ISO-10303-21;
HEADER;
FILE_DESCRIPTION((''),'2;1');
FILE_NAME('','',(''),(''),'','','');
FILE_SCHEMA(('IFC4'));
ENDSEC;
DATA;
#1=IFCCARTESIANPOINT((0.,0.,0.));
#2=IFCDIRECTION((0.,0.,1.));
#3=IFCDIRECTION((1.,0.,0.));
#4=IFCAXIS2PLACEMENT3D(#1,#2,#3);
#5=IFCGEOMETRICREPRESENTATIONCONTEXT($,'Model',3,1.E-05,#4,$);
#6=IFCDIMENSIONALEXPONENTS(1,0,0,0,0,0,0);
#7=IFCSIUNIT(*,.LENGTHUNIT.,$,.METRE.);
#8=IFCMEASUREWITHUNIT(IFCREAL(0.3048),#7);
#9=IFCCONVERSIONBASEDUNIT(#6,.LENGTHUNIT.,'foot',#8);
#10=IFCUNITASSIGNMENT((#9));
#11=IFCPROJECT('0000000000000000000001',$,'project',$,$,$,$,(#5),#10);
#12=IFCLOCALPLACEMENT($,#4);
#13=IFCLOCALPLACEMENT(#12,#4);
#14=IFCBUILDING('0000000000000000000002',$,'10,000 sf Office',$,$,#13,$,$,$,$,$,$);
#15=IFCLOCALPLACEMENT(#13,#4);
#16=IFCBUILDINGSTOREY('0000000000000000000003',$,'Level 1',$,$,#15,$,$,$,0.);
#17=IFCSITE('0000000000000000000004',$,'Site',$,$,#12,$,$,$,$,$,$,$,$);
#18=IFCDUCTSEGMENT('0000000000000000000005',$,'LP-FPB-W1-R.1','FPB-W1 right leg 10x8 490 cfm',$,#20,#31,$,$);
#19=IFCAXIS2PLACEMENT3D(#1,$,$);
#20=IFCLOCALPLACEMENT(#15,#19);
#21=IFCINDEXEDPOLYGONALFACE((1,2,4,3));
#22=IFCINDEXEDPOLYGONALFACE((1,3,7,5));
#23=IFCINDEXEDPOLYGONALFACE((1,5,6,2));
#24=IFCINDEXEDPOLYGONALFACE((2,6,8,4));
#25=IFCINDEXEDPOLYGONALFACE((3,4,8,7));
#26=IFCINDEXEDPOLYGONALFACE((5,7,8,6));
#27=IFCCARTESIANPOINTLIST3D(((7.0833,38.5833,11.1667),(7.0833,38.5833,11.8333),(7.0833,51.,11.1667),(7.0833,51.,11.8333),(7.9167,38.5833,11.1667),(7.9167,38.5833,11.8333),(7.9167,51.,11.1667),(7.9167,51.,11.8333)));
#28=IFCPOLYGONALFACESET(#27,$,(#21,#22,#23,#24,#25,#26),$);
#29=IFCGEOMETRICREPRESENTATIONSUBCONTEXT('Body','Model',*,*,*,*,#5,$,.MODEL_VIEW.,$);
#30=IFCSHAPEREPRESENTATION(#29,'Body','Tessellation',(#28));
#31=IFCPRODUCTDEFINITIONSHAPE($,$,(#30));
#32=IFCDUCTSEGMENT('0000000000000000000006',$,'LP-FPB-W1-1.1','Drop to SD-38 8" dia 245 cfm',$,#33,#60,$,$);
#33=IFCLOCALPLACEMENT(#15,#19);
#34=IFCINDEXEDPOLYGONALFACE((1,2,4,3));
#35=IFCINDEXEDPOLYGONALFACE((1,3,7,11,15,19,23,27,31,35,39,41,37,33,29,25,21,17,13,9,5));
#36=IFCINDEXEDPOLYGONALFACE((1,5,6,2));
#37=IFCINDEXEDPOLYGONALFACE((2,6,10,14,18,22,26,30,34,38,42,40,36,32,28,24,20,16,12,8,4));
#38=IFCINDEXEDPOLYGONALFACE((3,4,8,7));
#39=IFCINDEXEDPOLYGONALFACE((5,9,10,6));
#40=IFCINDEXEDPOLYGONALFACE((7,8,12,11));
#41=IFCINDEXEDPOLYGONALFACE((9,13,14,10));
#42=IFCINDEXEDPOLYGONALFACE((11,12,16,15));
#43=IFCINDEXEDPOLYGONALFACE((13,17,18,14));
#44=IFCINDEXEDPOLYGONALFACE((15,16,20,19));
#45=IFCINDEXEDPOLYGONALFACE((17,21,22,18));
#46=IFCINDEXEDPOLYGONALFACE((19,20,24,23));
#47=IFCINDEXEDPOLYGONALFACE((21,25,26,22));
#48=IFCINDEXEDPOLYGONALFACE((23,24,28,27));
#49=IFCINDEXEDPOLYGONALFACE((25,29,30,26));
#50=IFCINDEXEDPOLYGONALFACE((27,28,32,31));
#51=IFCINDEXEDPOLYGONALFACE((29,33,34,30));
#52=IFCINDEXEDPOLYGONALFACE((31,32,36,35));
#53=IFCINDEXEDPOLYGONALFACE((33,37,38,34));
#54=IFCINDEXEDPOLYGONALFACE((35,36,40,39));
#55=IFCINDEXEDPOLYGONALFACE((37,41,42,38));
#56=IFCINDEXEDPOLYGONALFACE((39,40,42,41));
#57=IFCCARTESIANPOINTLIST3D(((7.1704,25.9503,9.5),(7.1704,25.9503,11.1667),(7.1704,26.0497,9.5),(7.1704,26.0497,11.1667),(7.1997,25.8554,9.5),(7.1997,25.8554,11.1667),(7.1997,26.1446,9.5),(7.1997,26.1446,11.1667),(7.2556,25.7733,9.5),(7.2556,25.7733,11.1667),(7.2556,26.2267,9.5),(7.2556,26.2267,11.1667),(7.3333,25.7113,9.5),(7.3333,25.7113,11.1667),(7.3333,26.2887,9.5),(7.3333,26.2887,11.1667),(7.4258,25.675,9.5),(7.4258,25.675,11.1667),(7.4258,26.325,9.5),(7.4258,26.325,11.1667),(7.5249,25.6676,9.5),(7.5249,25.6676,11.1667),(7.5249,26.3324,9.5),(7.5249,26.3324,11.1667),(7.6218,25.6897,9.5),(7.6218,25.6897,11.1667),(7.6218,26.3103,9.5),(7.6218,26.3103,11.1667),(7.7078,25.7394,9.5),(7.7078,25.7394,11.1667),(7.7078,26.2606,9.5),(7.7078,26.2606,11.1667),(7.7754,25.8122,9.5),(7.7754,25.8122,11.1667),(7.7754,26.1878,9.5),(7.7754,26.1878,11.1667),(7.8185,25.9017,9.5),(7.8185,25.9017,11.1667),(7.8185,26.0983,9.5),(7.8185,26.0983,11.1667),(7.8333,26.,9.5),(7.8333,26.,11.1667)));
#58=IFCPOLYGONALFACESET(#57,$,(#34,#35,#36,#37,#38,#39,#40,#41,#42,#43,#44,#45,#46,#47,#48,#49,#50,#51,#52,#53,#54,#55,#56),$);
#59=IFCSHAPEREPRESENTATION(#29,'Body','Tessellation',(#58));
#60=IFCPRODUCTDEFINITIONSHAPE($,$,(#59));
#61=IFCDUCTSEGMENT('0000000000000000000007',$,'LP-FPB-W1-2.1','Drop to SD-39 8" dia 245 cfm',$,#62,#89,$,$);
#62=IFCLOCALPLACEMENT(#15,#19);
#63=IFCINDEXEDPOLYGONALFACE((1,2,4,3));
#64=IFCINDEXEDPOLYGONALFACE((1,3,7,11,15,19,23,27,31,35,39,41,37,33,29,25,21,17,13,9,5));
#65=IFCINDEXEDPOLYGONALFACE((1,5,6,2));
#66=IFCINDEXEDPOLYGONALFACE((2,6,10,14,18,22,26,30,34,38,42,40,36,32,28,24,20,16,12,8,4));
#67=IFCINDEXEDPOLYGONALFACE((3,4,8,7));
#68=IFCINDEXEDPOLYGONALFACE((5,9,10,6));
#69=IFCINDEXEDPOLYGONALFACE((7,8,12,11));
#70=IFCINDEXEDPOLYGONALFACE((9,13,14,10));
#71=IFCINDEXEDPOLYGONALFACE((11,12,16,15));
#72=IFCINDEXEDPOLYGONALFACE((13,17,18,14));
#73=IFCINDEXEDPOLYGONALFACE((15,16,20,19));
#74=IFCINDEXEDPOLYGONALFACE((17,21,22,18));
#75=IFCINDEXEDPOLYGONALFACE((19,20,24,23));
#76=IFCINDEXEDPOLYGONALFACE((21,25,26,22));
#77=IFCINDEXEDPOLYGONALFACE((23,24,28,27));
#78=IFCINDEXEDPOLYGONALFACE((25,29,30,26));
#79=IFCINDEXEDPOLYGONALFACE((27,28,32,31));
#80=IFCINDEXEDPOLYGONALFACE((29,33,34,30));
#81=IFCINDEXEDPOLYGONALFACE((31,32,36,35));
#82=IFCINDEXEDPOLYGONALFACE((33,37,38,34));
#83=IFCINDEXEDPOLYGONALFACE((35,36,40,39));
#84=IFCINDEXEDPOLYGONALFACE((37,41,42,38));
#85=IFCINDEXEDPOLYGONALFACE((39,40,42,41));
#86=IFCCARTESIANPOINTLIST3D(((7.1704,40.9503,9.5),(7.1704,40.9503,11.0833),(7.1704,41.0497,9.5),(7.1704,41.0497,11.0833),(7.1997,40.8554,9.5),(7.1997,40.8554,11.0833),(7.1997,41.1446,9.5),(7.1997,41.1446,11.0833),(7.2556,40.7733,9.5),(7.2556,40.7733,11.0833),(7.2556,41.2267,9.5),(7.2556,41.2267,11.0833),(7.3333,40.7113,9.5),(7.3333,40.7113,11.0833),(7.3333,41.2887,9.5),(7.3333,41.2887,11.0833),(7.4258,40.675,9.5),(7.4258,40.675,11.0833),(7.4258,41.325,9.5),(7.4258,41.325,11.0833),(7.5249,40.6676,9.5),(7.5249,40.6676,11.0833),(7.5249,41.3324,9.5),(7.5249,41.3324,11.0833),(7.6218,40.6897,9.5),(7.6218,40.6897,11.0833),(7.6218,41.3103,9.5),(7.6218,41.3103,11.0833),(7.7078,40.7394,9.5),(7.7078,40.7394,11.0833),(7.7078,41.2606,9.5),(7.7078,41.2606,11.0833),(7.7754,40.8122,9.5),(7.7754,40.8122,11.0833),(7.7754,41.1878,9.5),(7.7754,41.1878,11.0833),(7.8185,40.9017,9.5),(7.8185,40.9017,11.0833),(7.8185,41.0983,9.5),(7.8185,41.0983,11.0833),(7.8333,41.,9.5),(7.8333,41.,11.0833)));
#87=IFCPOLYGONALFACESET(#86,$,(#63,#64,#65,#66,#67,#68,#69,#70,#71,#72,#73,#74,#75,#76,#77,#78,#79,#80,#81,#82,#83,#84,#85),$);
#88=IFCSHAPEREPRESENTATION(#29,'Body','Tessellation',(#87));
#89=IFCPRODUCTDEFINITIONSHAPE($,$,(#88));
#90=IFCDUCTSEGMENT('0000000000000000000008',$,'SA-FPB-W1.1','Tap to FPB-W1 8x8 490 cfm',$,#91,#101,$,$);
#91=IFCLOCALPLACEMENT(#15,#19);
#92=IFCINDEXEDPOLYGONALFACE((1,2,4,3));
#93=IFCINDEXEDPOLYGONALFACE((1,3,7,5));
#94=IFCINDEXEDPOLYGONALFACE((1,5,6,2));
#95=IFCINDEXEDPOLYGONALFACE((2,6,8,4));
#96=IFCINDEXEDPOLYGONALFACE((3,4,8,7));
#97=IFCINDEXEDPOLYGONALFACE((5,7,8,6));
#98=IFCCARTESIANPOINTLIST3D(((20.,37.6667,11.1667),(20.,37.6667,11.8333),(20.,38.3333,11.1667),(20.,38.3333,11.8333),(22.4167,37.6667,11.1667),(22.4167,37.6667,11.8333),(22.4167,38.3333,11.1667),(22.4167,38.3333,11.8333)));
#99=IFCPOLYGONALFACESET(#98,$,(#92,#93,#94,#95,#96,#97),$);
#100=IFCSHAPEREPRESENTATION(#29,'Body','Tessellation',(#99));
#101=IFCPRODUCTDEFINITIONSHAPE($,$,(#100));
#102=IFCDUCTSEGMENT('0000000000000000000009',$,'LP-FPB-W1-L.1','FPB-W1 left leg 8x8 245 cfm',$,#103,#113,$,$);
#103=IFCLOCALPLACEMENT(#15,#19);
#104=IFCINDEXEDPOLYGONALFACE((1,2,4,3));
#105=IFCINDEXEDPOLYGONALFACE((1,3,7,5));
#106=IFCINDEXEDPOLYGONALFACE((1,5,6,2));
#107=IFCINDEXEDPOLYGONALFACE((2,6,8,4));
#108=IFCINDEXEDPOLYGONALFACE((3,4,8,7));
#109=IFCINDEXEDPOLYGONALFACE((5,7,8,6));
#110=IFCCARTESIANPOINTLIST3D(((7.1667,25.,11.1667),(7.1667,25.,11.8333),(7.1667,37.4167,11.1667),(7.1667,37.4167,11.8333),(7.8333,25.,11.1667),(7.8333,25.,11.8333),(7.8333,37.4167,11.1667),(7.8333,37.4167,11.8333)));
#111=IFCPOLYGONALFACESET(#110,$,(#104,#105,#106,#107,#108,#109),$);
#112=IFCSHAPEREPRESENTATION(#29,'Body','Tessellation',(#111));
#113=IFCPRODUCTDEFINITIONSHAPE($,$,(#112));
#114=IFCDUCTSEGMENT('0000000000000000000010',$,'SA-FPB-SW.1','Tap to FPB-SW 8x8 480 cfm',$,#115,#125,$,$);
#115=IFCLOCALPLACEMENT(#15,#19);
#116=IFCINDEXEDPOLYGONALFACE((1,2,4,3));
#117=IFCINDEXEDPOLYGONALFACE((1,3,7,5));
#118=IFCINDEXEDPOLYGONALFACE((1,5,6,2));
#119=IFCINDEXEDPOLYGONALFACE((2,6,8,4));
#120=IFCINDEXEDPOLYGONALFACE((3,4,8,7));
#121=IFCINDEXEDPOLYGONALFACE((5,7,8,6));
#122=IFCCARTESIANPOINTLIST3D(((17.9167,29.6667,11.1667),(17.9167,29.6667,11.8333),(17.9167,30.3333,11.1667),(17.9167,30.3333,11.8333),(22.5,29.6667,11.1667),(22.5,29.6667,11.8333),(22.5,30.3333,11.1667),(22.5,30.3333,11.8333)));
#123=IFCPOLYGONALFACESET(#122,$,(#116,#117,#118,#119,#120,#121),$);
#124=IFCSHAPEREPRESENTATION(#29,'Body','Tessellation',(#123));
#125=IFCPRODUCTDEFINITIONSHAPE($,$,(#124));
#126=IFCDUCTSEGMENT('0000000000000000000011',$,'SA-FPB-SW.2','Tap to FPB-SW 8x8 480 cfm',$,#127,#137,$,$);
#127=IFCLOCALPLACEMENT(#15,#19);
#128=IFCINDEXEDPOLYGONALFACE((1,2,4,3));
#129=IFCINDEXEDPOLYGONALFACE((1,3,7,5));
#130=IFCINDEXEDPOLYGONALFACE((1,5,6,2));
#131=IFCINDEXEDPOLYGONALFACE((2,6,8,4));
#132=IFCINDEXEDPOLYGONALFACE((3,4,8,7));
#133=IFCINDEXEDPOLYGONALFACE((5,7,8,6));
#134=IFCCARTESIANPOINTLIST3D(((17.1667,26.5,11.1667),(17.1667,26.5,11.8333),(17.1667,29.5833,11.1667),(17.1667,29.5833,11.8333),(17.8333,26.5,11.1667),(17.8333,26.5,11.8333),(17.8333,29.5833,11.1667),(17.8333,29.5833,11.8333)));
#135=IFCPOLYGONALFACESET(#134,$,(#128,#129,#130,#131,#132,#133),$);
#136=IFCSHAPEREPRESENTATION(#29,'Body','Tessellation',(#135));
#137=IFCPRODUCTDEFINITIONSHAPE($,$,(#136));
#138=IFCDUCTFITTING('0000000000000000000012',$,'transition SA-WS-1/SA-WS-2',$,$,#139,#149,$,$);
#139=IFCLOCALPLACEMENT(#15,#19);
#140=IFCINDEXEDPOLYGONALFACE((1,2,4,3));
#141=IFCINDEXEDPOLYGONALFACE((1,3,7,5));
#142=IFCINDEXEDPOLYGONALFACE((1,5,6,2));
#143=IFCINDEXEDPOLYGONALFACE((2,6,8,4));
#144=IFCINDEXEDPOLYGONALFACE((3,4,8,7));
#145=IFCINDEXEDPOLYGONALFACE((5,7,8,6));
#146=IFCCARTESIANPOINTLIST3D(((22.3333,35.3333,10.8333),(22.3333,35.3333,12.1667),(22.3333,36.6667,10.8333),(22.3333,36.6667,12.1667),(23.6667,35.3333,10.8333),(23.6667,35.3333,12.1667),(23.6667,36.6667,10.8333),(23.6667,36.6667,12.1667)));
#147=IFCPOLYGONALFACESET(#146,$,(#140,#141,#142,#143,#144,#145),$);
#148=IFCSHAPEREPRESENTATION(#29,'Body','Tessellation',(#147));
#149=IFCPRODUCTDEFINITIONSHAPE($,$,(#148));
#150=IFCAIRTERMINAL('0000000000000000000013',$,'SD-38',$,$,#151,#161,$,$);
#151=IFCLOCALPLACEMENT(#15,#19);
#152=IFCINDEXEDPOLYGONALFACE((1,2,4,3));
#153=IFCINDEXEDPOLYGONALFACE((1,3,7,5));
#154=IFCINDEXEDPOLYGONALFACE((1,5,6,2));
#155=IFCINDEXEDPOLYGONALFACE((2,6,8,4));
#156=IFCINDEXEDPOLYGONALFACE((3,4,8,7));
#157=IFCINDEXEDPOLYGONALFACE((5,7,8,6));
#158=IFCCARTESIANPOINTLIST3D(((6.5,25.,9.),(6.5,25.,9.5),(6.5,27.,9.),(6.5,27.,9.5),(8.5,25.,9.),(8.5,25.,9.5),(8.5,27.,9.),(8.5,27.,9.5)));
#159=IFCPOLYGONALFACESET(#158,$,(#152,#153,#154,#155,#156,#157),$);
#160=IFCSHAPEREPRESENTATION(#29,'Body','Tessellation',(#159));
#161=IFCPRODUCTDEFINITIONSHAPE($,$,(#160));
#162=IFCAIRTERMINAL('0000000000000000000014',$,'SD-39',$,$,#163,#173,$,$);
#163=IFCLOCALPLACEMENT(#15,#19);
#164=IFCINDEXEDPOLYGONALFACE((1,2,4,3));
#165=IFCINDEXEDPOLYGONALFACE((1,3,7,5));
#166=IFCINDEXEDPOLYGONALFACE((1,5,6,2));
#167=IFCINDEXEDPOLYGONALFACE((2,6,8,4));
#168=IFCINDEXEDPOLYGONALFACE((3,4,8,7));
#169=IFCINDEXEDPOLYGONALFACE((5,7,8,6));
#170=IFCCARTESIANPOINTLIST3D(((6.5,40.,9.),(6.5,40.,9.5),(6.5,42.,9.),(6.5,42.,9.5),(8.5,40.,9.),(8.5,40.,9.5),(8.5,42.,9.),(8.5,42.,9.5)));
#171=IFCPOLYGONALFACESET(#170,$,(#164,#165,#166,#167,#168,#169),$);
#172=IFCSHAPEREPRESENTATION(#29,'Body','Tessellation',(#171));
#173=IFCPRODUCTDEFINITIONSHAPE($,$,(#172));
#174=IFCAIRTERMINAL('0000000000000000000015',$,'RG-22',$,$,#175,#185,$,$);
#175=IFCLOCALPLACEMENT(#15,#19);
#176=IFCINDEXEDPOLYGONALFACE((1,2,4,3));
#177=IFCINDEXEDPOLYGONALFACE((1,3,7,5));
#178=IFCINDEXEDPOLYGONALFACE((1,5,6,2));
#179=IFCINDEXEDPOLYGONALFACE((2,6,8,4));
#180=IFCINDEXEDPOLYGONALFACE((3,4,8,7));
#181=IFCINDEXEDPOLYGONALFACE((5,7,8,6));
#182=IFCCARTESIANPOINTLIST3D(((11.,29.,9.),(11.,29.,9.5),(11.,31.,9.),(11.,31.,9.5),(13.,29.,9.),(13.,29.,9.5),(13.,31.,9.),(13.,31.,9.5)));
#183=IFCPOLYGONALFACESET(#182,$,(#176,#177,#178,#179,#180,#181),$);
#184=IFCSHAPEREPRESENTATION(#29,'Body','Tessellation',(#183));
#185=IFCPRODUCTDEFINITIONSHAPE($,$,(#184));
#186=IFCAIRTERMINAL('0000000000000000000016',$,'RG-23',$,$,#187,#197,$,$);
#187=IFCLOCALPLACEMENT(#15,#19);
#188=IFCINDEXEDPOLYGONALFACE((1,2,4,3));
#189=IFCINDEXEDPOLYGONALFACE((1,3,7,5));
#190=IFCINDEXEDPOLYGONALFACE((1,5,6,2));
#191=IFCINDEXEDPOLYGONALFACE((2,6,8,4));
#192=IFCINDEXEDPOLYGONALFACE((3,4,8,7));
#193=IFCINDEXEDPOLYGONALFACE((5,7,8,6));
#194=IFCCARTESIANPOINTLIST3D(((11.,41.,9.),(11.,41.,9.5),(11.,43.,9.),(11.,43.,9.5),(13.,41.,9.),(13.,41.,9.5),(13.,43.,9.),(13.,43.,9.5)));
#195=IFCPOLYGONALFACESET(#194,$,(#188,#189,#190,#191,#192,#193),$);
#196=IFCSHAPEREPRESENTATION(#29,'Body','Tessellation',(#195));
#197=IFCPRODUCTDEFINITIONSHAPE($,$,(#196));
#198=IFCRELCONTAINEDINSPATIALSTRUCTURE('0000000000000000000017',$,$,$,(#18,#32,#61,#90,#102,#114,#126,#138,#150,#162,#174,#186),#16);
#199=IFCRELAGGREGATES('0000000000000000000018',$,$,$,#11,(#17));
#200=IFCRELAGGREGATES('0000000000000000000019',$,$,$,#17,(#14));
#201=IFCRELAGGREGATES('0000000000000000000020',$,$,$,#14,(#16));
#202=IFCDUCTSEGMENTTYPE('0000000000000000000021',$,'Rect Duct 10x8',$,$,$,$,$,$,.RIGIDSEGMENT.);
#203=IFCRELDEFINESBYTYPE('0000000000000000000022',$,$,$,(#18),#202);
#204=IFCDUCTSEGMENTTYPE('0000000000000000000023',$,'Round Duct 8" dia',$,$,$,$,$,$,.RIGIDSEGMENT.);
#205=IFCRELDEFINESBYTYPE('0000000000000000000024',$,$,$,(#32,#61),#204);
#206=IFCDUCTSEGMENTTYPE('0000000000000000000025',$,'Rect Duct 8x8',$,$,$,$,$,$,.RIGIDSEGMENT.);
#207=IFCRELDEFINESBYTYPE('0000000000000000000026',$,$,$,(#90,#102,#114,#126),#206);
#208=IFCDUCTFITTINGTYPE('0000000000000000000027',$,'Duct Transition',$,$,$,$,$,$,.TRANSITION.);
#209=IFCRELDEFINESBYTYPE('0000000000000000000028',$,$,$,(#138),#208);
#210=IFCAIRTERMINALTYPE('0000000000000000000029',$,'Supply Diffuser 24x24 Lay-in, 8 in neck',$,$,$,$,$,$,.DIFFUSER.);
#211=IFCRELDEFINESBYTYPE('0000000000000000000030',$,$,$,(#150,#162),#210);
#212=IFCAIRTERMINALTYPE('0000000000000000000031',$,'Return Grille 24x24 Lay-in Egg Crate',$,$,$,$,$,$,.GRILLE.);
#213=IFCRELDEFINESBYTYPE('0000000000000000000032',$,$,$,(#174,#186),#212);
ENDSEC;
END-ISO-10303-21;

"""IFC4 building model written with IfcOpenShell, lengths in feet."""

from ifc_helpers import new_model, entity, si_unit, converted_unit, frame, origin_with_axes, place, context, subcontext, project, spatial, rectangle, circle, extrude, type_object, element, save


model = new_model("IFC4")

# Units and contexts
model_context = context("Model", 3, precision=1e-05, world=origin_with_axes())
body_context = subcontext(model_context, "Body", "Model", "MODEL_VIEW")
ifc_project = project(units=[converted_unit("LENGTHUNIT", "foot", entity("IfcReal", 0.3048), si_unit("LENGTHUNIT", "METRE"), dimensions=[1, 0, 0, 0, 0, 0, 0])], contexts=[model_context])

# Site, building, storey
site_placement = place(None, origin_with_axes())
site = spatial("IfcSite", under=ifc_project, at=site_placement, Name="Site")
building_placement = place(site_placement, origin_with_axes())
building = spatial("IfcBuilding", under=site, at=building_placement, Name="10,000 sf Office")
storey_placement = place(building_placement, origin_with_axes())
storey = spatial("IfcBuildingStorey", under=building, at=storey_placement, Name="Level 1", Elevation=0.0)

# Duct segments
duct_segment_type_1 = type_object("IfcDuctSegmentType", Name="Rect Duct 10x8", PredefinedType="RIGIDSEGMENT")
duct_segment_1_placement = place(storey_placement, frame((7.5, 38.5833, 11.5), z_axis=(0.0, 1.0, 0.0), x_axis=(-1.0, 0.0, 0.0)))
element("IfcDuctSegment", 1, at=duct_segment_1_placement, inside=storey, type_object=duct_segment_type_1, Name="LP-FPB-W1-R.1", Description="FPB-W1 right leg 10x8 490 cfm", context=body_context, shape_type="SweptSolid", body=[
    extrude(rectangle(XDim=0.8333, YDim=0.6667), None, (0.0, 0.0, 1.0), 12.4167),
])
duct_segment_type_2 = type_object("IfcDuctSegmentType", Name="Round Duct 8\" dia", PredefinedType="RIGIDSEGMENT")
duct_segment_2_placement = place(storey_placement, frame((7.5, 26.0, 11.1667), z_axis=(0.0, 0.0, -1.0), x_axis=(1.0, 0.0, 0.0)))
element("IfcDuctSegment", 2, at=duct_segment_2_placement, inside=storey, type_object=duct_segment_type_2, Name="LP-FPB-W1-1.1", Description="Drop to SD-38 8\" dia 245 cfm", context=body_context, shape_type="SweptSolid", body=[
    extrude(circle(Radius=0.3333), None, (0.0, 0.0, 1.0), 1.6667),
])
duct_segment_3_placement = place(storey_placement, frame((7.5, 41.0, 11.0833), z_axis=(0.0, 0.0, -1.0), x_axis=(1.0, 0.0, 0.0)))
element("IfcDuctSegment", 3, at=duct_segment_3_placement, inside=storey, type_object=duct_segment_type_2, Name="LP-FPB-W1-2.1", Description="Drop to SD-39 8\" dia 245 cfm", context=body_context, shape_type="SweptSolid", body=[
    extrude(circle(Radius=0.3333), None, (0.0, 0.0, 1.0), 1.5833),
])
duct_segment_type_3 = type_object("IfcDuctSegmentType", Name="Rect Duct 8x8", PredefinedType="RIGIDSEGMENT")
duct_segment_4_placement = place(storey_placement, frame((22.4167, 38.0, 11.5), z_axis=(-1.0, 0.0, 0.0), x_axis=(0.0, -1.0, 0.0)))
element("IfcDuctSegment", 4, at=duct_segment_4_placement, inside=storey, type_object=duct_segment_type_3, Name="SA-FPB-W1.1", Description="Tap to FPB-W1 8x8 490 cfm", context=body_context, shape_type="SweptSolid", body=[
    extrude(rectangle(XDim=0.6667, YDim=0.6667), None, (0.0, 0.0, 1.0), 2.4167),
])
duct_segment_5_placement = place(storey_placement, frame((7.5, 37.4167, 11.5), z_axis=(0.0, -1.0, 0.0), x_axis=(1.0, 0.0, 0.0)))
element("IfcDuctSegment", 5, at=duct_segment_5_placement, inside=storey, type_object=duct_segment_type_3, Name="LP-FPB-W1-L.1", Description="FPB-W1 left leg 8x8 245 cfm", context=body_context, shape_type="SweptSolid", body=[
    extrude(rectangle(XDim=0.6667, YDim=0.6667), None, (0.0, 0.0, 1.0), 12.4167),
])
duct_segment_6_placement = place(storey_placement, frame((22.5, 30.0, 11.5), z_axis=(-1.0, 0.0, 0.0), x_axis=(0.0, -1.0, 0.0)))
element("IfcDuctSegment", 6, at=duct_segment_6_placement, inside=storey, type_object=duct_segment_type_3, Name="SA-FPB-SW.1", Description="Tap to FPB-SW 8x8 480 cfm", context=body_context, shape_type="SweptSolid", body=[
    extrude(rectangle(XDim=0.6667, YDim=0.6667), None, (0.0, 0.0, 1.0), 4.5833),
])
duct_segment_7_placement = place(storey_placement, frame((17.5, 29.5833, 11.5), z_axis=(0.0, -1.0, 0.0), x_axis=(1.0, 0.0, 0.0)))
element("IfcDuctSegment", 7, at=duct_segment_7_placement, inside=storey, type_object=duct_segment_type_3, Name="SA-FPB-SW.2", Description="Tap to FPB-SW 8x8 480 cfm", context=body_context, shape_type="SweptSolid", body=[
    extrude(rectangle(XDim=0.6667, YDim=0.6667), None, (0.0, 0.0, 1.0), 3.0833),
])

# Duct fitting
duct_fitting_type_1 = type_object("IfcDuctFittingType", Name="Duct Transition", PredefinedType="TRANSITION")
duct_fitting_1_placement = place(storey_placement, frame((23.0, 36.0, 10.8333), z_axis=(0.0, 0.0, 1.0), x_axis=(1.0, 0.0, 0.0)))
element("IfcDuctFitting", 8, at=duct_fitting_1_placement, inside=storey, type_object=duct_fitting_type_1, Name="transition SA-WS-1/SA-WS-2", context=body_context, shape_type="SweptSolid", body=[
    extrude(rectangle(XDim=1.3333, YDim=1.3333), None, (0.0, 0.0, 1.0), 1.3333),
])

# Air terminals
air_terminal_type_1 = type_object("IfcAirTerminalType", Name="Supply Diffuser 24x24 Lay-in, 8 in neck", PredefinedType="DIFFUSER")
for number, where, z_axis, x_axis, name in (
    (9, (7.5, 26.0, 9.0), (0.0, 0.0, 1.0), (1.0, 0.0, 0.0), "SD-38"),
    (10, (7.5, 41.0, 9.0), (0.0, 0.0, 1.0), (1.0, 0.0, 0.0), "SD-39"),
):
    element("IfcAirTerminal", number, at=place(storey_placement, frame(where, z_axis=z_axis, x_axis=x_axis)), inside=storey, type_object=air_terminal_type_1, Name=name, context=body_context, shape_type="SweptSolid", body=[
        extrude(rectangle(XDim=2.0, YDim=2.0), None, (0.0, 0.0, 1.0), 0.5),
    ])
air_terminal_type_2 = type_object("IfcAirTerminalType", Name="Return Grille 24x24 Lay-in Egg Crate", PredefinedType="GRILLE")
for number, where, z_axis, x_axis, name in (
    (11, (12.0, 30.0, 9.0), (0.0, 0.0, 1.0), (1.0, 0.0, 0.0), "RG-22"),
    (12, (12.0, 42.0, 9.0), (0.0, 0.0, 1.0), (1.0, 0.0, 0.0), "RG-23"),
):
    element("IfcAirTerminal", number, at=place(storey_placement, frame(where, z_axis=z_axis, x_axis=x_axis)), inside=storey, type_object=air_terminal_type_2, Name=name, context=body_context, shape_type="SweptSolid", body=[
        extrude(rectangle(XDim=2.0, YDim=2.0), None, (0.0, 0.0, 1.0), 0.5),
    ])

save(model, "model.ifc")
